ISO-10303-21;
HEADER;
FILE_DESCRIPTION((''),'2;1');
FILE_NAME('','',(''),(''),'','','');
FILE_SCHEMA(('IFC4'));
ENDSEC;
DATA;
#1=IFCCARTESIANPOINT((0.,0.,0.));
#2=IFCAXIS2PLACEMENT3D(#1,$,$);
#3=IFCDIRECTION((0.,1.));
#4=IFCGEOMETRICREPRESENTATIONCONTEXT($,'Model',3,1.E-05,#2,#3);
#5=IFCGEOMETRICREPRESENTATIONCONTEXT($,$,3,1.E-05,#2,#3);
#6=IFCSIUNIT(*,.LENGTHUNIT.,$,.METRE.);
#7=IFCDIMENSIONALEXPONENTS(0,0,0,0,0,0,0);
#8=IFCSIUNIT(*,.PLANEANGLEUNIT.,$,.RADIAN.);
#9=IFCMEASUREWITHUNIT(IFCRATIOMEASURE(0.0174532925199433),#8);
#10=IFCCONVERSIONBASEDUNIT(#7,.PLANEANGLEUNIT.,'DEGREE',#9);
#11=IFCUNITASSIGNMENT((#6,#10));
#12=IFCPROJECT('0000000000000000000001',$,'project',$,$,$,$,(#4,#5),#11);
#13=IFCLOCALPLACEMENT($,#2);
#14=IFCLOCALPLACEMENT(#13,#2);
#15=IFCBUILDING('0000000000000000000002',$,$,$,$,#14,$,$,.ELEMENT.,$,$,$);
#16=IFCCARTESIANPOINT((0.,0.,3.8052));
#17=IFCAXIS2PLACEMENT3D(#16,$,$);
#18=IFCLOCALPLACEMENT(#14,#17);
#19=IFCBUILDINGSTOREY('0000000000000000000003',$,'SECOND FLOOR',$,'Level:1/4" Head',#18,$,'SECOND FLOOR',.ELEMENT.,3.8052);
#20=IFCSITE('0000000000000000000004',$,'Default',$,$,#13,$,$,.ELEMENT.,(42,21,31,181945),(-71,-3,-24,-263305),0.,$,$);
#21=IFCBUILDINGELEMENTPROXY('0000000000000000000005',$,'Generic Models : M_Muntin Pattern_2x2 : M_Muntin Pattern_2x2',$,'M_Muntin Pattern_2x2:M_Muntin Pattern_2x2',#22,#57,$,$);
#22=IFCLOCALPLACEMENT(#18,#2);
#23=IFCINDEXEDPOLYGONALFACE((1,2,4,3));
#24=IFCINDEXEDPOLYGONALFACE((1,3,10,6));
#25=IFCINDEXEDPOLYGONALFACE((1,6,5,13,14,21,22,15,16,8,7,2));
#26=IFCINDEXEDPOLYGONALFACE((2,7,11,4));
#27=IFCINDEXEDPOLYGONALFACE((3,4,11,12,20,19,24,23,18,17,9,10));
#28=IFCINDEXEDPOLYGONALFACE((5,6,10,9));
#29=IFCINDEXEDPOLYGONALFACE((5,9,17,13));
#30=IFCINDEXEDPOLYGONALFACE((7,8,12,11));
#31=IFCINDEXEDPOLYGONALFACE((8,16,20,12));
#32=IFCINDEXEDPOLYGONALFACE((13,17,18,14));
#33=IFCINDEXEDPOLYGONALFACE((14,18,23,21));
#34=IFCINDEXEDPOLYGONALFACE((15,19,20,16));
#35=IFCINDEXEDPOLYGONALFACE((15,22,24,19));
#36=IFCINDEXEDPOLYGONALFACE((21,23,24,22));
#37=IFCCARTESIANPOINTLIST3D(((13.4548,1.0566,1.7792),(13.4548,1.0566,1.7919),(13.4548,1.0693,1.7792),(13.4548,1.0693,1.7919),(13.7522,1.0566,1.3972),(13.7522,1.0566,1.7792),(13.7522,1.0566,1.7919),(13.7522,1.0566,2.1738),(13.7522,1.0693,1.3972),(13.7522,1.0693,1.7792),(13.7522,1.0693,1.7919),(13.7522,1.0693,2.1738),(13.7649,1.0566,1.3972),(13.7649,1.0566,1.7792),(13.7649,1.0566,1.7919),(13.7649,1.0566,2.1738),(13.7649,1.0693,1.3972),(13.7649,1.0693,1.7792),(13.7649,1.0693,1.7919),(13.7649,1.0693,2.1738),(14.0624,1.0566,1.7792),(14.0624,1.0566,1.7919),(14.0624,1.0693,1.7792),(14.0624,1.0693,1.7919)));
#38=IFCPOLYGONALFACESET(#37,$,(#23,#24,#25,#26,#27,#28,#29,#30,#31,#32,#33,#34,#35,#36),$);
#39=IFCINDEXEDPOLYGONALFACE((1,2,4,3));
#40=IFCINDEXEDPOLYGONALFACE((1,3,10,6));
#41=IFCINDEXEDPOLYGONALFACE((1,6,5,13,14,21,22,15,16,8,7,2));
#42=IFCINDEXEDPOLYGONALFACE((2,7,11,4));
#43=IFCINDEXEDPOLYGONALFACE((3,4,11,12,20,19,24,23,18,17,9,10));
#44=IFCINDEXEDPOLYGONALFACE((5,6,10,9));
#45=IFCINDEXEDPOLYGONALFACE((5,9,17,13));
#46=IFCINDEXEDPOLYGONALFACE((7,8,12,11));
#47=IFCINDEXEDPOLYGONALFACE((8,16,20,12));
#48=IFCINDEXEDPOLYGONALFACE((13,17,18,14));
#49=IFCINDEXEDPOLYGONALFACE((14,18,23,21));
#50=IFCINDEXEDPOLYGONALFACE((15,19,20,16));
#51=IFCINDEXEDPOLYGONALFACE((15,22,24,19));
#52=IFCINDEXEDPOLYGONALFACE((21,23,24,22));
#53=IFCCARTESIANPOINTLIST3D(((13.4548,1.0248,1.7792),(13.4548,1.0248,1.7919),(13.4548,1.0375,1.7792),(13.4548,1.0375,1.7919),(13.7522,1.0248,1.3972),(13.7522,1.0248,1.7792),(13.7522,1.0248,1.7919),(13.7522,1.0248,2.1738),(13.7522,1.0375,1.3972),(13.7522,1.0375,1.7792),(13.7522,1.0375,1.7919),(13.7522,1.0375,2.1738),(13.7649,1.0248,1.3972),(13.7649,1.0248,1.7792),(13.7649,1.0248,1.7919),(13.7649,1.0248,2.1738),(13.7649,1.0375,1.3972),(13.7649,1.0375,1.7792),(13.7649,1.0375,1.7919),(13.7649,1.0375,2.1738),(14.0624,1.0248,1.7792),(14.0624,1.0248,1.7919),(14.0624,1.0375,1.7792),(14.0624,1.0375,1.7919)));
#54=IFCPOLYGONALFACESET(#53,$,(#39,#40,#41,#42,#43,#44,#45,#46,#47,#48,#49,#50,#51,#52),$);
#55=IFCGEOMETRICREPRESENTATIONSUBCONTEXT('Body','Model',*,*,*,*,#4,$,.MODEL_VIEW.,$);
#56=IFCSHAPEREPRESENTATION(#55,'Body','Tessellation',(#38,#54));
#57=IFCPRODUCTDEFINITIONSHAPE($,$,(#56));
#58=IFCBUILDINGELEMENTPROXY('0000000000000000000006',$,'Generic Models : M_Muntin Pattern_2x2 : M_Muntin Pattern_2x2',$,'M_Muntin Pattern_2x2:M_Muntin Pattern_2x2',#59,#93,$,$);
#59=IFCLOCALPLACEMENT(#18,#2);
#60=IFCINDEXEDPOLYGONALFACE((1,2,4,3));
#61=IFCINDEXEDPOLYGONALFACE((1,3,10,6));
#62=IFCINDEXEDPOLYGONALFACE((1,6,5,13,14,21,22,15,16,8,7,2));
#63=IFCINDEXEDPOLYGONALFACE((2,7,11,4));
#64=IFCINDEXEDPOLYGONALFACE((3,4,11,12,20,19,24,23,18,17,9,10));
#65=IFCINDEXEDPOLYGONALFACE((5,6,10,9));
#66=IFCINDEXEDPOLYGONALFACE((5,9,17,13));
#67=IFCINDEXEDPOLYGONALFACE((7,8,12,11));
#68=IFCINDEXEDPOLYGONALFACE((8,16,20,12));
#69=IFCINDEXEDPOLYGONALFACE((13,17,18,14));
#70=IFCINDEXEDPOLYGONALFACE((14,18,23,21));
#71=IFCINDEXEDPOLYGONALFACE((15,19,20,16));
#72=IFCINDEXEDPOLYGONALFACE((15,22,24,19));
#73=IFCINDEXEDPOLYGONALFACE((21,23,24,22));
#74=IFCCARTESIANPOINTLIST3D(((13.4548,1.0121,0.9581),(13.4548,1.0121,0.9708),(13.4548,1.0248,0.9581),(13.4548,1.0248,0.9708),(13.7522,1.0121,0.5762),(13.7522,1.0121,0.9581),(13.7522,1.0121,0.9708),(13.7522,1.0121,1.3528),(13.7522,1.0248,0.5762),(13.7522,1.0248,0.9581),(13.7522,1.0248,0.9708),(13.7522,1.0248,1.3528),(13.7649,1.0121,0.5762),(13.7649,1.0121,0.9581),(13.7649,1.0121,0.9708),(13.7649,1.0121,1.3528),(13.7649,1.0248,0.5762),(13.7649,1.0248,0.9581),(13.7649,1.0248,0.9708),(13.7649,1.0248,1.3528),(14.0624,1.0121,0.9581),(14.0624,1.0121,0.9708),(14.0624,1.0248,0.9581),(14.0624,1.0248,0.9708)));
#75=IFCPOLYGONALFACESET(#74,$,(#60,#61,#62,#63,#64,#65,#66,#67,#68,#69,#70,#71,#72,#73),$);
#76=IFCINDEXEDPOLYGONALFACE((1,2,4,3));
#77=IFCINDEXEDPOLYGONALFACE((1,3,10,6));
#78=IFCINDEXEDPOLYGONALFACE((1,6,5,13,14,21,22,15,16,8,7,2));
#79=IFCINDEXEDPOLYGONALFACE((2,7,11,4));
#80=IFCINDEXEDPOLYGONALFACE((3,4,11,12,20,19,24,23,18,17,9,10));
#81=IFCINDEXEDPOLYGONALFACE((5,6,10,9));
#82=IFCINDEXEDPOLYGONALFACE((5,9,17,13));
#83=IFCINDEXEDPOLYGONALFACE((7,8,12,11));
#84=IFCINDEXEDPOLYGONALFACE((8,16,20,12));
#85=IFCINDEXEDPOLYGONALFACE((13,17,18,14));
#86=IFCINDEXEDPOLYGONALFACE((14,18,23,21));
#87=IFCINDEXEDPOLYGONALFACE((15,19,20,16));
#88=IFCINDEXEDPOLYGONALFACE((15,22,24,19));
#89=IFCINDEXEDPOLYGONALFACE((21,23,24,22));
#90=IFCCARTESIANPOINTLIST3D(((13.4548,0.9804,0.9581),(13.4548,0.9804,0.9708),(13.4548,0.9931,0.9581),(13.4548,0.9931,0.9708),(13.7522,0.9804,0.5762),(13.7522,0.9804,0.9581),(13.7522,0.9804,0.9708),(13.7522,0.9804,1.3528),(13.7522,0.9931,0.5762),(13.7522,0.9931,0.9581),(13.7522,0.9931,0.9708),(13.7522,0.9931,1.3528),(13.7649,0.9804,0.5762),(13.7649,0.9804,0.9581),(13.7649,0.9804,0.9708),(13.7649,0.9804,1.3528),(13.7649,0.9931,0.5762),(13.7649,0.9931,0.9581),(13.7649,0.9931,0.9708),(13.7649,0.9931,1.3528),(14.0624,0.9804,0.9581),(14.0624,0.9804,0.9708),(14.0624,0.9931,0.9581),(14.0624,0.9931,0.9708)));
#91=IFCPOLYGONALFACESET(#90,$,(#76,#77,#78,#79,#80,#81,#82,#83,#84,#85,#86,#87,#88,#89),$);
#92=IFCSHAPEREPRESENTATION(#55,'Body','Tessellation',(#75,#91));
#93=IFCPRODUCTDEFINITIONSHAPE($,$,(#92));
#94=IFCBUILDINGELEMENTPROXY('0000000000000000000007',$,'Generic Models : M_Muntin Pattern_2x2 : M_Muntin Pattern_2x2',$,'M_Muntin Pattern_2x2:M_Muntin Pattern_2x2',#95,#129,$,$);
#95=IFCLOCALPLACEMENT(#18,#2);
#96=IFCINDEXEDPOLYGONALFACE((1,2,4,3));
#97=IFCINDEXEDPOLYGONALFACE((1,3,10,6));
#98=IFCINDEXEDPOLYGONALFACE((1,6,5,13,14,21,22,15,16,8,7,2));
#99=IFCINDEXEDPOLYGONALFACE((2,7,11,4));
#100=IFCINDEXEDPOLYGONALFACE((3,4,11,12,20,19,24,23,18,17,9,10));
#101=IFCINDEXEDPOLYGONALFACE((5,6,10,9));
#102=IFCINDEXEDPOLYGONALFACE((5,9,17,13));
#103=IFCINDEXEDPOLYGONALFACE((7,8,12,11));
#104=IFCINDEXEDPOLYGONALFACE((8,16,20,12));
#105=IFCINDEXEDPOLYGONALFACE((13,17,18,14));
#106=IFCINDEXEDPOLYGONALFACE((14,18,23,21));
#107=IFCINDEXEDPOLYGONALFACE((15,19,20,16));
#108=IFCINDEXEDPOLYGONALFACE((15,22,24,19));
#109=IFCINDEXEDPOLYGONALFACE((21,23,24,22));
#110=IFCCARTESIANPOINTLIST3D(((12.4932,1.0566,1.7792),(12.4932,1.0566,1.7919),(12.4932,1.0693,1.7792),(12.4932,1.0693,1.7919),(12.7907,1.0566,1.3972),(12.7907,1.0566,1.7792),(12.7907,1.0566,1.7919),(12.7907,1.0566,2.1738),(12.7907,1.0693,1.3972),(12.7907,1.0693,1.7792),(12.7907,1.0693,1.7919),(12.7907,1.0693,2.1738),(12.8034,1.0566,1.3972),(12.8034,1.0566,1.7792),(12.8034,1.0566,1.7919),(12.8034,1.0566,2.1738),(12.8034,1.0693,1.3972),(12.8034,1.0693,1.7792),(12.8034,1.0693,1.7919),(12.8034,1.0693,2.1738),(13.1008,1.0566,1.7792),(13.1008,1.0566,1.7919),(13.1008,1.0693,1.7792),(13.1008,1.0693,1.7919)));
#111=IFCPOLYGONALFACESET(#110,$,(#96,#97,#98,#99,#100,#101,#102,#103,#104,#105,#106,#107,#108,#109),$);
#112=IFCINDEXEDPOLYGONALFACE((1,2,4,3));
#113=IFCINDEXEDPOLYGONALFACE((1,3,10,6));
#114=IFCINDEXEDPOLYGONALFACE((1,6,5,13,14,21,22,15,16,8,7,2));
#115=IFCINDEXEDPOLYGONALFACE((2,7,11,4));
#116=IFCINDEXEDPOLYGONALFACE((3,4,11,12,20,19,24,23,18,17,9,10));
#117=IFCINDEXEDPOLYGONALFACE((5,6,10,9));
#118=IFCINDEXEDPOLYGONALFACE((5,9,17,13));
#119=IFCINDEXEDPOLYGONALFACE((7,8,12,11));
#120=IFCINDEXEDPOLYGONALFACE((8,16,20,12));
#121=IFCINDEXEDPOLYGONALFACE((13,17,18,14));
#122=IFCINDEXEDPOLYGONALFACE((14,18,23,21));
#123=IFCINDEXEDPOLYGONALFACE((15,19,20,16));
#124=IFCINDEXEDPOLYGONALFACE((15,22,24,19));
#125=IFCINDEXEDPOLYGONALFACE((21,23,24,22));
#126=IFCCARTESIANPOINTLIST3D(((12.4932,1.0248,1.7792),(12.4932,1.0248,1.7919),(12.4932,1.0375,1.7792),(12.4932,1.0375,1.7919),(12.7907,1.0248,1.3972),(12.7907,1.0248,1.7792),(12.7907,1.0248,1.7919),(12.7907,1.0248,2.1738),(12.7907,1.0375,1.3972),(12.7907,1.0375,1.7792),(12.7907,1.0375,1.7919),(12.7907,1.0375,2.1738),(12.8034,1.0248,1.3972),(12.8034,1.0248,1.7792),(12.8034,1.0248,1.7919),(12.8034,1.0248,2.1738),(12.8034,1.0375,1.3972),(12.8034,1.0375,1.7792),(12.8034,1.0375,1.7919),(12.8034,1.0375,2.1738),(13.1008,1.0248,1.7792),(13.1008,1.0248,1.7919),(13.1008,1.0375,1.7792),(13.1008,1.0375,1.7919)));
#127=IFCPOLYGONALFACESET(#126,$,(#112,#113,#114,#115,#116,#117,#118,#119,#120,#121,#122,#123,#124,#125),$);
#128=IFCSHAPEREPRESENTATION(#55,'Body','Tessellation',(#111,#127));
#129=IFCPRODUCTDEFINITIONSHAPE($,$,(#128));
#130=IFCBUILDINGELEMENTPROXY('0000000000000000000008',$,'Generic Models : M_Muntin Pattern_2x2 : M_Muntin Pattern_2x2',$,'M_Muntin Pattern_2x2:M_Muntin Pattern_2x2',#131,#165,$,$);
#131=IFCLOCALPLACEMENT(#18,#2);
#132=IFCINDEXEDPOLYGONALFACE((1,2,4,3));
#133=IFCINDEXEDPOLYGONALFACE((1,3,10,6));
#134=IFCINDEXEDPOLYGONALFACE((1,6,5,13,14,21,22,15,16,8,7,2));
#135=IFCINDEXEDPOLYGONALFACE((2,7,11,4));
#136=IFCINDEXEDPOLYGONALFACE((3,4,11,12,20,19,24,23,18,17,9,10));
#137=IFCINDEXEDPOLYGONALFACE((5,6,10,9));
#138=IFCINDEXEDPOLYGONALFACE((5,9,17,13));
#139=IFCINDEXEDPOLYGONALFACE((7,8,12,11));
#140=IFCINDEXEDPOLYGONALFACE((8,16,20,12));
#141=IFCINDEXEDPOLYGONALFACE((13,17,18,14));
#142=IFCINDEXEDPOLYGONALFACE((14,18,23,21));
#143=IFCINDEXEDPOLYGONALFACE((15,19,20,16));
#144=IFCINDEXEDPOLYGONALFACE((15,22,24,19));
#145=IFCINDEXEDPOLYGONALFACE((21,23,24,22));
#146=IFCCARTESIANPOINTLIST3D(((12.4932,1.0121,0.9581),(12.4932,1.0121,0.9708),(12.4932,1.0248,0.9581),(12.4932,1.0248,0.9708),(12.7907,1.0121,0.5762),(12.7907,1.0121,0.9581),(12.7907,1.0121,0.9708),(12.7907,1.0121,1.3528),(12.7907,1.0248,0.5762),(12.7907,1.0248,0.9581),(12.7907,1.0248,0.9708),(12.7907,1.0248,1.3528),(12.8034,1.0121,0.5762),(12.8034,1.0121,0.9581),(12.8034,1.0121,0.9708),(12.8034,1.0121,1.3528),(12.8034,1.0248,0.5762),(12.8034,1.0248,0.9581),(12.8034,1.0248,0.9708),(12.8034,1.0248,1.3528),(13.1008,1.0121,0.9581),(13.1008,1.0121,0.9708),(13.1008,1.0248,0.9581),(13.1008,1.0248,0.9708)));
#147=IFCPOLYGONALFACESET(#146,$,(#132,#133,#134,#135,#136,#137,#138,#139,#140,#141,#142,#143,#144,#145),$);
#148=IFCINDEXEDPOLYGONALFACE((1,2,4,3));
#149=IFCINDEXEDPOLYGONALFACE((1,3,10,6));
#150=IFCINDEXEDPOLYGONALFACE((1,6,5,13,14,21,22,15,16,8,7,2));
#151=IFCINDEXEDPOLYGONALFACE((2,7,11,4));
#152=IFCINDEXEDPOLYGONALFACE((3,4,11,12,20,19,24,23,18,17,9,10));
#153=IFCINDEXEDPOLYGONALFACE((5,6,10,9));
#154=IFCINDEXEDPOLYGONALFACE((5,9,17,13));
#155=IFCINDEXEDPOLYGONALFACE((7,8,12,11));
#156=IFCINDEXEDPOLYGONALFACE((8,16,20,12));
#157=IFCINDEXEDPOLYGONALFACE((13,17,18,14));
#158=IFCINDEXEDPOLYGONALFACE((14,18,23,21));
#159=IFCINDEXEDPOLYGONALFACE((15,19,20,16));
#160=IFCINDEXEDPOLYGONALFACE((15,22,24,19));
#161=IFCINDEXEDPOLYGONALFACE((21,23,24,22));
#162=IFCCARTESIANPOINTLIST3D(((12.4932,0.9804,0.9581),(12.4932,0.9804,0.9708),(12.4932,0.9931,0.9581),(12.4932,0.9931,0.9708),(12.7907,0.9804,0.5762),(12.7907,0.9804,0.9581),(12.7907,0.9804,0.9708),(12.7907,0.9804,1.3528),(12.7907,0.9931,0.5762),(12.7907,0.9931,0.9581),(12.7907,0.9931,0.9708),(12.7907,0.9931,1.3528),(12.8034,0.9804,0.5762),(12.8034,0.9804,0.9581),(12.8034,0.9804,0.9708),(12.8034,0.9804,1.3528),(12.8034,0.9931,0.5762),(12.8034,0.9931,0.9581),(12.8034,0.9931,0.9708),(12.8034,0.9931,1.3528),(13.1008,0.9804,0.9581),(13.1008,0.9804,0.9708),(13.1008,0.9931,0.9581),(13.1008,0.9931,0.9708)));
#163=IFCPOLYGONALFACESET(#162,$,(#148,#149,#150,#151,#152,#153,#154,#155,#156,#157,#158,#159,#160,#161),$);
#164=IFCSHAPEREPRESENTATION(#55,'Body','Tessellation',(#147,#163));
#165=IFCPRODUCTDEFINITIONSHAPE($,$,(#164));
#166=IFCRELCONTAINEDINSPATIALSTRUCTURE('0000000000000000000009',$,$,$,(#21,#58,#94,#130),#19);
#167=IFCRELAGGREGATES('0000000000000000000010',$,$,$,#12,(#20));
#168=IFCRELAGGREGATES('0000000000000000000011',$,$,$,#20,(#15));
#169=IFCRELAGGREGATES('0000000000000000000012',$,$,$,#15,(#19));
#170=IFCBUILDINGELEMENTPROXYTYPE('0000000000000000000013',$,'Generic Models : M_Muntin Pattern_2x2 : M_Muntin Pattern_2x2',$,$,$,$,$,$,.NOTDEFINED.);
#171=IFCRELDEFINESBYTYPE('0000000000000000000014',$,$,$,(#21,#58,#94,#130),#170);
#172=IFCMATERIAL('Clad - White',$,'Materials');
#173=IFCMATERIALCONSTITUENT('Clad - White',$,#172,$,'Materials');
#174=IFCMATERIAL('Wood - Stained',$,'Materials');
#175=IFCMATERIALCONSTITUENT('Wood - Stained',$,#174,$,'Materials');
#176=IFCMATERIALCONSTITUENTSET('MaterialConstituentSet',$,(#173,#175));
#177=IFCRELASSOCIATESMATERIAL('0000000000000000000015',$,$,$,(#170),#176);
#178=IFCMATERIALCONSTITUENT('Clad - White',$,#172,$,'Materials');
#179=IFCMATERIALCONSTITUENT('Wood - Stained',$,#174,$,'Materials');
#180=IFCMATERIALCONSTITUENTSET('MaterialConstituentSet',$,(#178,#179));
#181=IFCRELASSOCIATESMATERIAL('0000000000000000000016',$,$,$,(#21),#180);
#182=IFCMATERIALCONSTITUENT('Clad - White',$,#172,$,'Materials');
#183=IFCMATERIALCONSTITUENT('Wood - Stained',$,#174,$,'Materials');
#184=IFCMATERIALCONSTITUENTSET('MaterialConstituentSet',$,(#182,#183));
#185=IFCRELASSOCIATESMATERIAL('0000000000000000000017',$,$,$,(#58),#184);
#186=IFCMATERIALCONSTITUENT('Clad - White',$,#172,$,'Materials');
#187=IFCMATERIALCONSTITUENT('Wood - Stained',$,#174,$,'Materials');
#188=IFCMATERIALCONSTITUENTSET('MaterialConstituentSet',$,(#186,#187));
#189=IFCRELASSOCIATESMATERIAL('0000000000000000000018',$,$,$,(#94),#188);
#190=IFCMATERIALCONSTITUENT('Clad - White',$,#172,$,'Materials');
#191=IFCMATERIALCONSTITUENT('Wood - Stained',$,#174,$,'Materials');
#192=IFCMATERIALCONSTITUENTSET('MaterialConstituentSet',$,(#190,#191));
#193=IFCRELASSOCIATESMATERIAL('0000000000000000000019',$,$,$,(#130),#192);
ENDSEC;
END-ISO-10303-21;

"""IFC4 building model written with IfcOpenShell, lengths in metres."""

from ifc_helpers import new_model, entity, si_unit, converted_unit, direction, frame, origin, place, context, subcontext, project, spatial, polyline, outline, extrude, source, transform, mapped, material, constituent, constituent_set, type_object, type_shapes, element, save


model = new_model("IFC4")

# Units and contexts
model_context = context("Model", 3, precision=1e-05, world=origin(), true_north=direction((0.0, 1.0)))
context_of_model = context(None, 3, precision=1e-05, world=origin(), true_north=direction((0.0, 1.0)))
body_context = subcontext(model_context, "Body", "Model", "MODEL_VIEW")
ifc_project = project(units=[si_unit("LENGTHUNIT", "METRE"), converted_unit("PLANEANGLEUNIT", "DEGREE", entity("IfcRatioMeasure", 0.0174532925199433), si_unit("PLANEANGLEUNIT", "RADIAN"), dimensions=[0, 0, 0, 0, 0, 0, 0])], contexts=[model_context, context_of_model])

# Site, building, storey
site_placement = place(None, origin())
site = spatial("IfcSite", under=ifc_project, at=site_placement, Name="Default", CompositionType="ELEMENT", RefLatitude=(42, 21, 31, 181945), RefLongitude=(-71, -3, -24, -263305), RefElevation=0.0)
building_placement = place(site_placement, origin())
building = spatial("IfcBuilding", under=site, at=building_placement, CompositionType="ELEMENT")
storey_placement = place(building_placement, frame((0.0, 0.0, 3.8052)))
storey = spatial("IfcBuildingStorey", under=building, at=storey_placement, Name="SECOND FLOOR", ObjectType="Level:1/4\" Head", LongName="SECOND FLOOR", CompositionType="ELEMENT", Elevation=3.8052)

# Building element proxies
ifc_material_1 = material(Name="Clad - White", Category="Materials")
ifc_constituent_1 = constituent(ifc_material_1, Name="Clad - White", Category="Materials")
ifc_material_2 = material(Name="Wood - Stained", Category="Materials")
ifc_constituent_2 = constituent(ifc_material_2, Name="Wood - Stained", Category="Materials")
ifc_constituent_set_1 = constituent_set(constituents=[ifc_constituent_1, ifc_constituent_2], Name="MaterialConstituentSet")
ifc_constituent_3 = constituent(ifc_material_1, Name="Clad - White", Category="Materials")
ifc_constituent_4 = constituent(ifc_material_2, Name="Wood - Stained", Category="Materials")
ifc_constituent_set_2 = constituent_set(constituents=[ifc_constituent_3, ifc_constituent_4], Name="MaterialConstituentSet")
building_element_proxy_type_1 = type_object("IfcBuildingElementProxyType", Name="Generic Models : M_Muntin Pattern_2x2 : M_Muntin Pattern_2x2", PredefinedType="NOTDEFINED", material=ifc_constituent_set_2)
shared_shape_1 = source(origin(), body_context, "Body", "SweptSolid", [
    extrude(outline(polyline([(0.0064, -0.0064), (0.3883, -0.0064), (0.3883, 0.0063), (0.0064, 0.0063), (0.0064, 0.3038), (-0.0063, 0.3038), (-0.0063, 0.0063), (-0.3883, 0.0063), (-0.3883, -0.0064), (-0.0063, -0.0064), (-0.0063, -0.3038), (0.0064, -0.3038), (0.0064, -0.0064)])), frame((0.0, 0.0095, 0.3883), z_axis=(0.0, 1.0, 0.0), x_axis=(0.0, 0.0, 1.0)), (0.0, 0.0, 1.0), 0.0127),
    extrude(outline(polyline([(0.0064, -0.0064), (0.3883, -0.0064), (0.3883, 0.0063), (0.0064, 0.0063), (0.0064, 0.3038), (-0.0063, 0.3038), (-0.0063, 0.0063), (-0.3883, 0.0063), (-0.3883, -0.0064), (-0.0063, -0.0064), (-0.0063, -0.3038), (0.0064, -0.3038), (0.0064, -0.0064)])), frame((0.0, -0.0222, 0.3883), z_axis=(0.0, 1.0, 0.0), x_axis=(0.0, 0.0, 1.0)), (0.0, 0.0, 1.0), 0.0127),
])
type_shapes(building_element_proxy_type_1, [shared_shape_1])
proxy_1_placement = place(storey_placement, frame((13.7586, 1.047, 1.3972)))
element("IfcBuildingElementProxy", 1, at=proxy_1_placement, inside=storey, type_object=building_element_proxy_type_1, material=ifc_constituent_set_1, Name="Generic Models : M_Muntin Pattern_2x2 : M_Muntin Pattern_2x2", ObjectType="M_Muntin Pattern_2x2:M_Muntin Pattern_2x2", context=body_context, shape_type="MappedRepresentation", body=[
    mapped(shared_shape_1, transform((0.0, 0.0, 0.0), scale=1.0)),
])
ifc_constituent_5 = constituent(ifc_material_1, Name="Clad - White", Category="Materials")
ifc_constituent_6 = constituent(ifc_material_2, Name="Wood - Stained", Category="Materials")
ifc_constituent_set_3 = constituent_set(constituents=[ifc_constituent_5, ifc_constituent_6], Name="MaterialConstituentSet")
proxy_2_placement = place(storey_placement, frame((13.7586, 1.0026, 0.5762)))
element("IfcBuildingElementProxy", 2, at=proxy_2_placement, inside=storey, type_object=building_element_proxy_type_1, material=ifc_constituent_set_3, Name="Generic Models : M_Muntin Pattern_2x2 : M_Muntin Pattern_2x2", ObjectType="M_Muntin Pattern_2x2:M_Muntin Pattern_2x2", context=body_context, shape_type="MappedRepresentation", body=[
    mapped(shared_shape_1, transform((0.0, 0.0, 0.0), scale=1.0)),
])
ifc_constituent_7 = constituent(ifc_material_1, Name="Clad - White", Category="Materials")
ifc_constituent_8 = constituent(ifc_material_2, Name="Wood - Stained", Category="Materials")
ifc_constituent_set_4 = constituent_set(constituents=[ifc_constituent_7, ifc_constituent_8], Name="MaterialConstituentSet")
proxy_3_placement = place(storey_placement, frame((12.797, 1.047, 1.3972)))
element("IfcBuildingElementProxy", 3, at=proxy_3_placement, inside=storey, type_object=building_element_proxy_type_1, material=ifc_constituent_set_4, Name="Generic Models : M_Muntin Pattern_2x2 : M_Muntin Pattern_2x2", ObjectType="M_Muntin Pattern_2x2:M_Muntin Pattern_2x2", context=body_context, shape_type="MappedRepresentation", body=[
    mapped(shared_shape_1, transform((0.0, 0.0, 0.0), scale=1.0)),
])
ifc_constituent_9 = constituent(ifc_material_1, Name="Clad - White", Category="Materials")
ifc_constituent_10 = constituent(ifc_material_2, Name="Wood - Stained", Category="Materials")
ifc_constituent_set_5 = constituent_set(constituents=[ifc_constituent_9, ifc_constituent_10], Name="MaterialConstituentSet")
proxy_4_placement = place(storey_placement, frame((12.797, 1.0026, 0.5762)))
element("IfcBuildingElementProxy", 4, at=proxy_4_placement, inside=storey, type_object=building_element_proxy_type_1, material=ifc_constituent_set_5, Name="Generic Models : M_Muntin Pattern_2x2 : M_Muntin Pattern_2x2", ObjectType="M_Muntin Pattern_2x2:M_Muntin Pattern_2x2", context=body_context, shape_type="MappedRepresentation", body=[
    mapped(shared_shape_1, transform((0.0, 0.0, 0.0), scale=1.0)),
])

save(model, "model.ifc")
